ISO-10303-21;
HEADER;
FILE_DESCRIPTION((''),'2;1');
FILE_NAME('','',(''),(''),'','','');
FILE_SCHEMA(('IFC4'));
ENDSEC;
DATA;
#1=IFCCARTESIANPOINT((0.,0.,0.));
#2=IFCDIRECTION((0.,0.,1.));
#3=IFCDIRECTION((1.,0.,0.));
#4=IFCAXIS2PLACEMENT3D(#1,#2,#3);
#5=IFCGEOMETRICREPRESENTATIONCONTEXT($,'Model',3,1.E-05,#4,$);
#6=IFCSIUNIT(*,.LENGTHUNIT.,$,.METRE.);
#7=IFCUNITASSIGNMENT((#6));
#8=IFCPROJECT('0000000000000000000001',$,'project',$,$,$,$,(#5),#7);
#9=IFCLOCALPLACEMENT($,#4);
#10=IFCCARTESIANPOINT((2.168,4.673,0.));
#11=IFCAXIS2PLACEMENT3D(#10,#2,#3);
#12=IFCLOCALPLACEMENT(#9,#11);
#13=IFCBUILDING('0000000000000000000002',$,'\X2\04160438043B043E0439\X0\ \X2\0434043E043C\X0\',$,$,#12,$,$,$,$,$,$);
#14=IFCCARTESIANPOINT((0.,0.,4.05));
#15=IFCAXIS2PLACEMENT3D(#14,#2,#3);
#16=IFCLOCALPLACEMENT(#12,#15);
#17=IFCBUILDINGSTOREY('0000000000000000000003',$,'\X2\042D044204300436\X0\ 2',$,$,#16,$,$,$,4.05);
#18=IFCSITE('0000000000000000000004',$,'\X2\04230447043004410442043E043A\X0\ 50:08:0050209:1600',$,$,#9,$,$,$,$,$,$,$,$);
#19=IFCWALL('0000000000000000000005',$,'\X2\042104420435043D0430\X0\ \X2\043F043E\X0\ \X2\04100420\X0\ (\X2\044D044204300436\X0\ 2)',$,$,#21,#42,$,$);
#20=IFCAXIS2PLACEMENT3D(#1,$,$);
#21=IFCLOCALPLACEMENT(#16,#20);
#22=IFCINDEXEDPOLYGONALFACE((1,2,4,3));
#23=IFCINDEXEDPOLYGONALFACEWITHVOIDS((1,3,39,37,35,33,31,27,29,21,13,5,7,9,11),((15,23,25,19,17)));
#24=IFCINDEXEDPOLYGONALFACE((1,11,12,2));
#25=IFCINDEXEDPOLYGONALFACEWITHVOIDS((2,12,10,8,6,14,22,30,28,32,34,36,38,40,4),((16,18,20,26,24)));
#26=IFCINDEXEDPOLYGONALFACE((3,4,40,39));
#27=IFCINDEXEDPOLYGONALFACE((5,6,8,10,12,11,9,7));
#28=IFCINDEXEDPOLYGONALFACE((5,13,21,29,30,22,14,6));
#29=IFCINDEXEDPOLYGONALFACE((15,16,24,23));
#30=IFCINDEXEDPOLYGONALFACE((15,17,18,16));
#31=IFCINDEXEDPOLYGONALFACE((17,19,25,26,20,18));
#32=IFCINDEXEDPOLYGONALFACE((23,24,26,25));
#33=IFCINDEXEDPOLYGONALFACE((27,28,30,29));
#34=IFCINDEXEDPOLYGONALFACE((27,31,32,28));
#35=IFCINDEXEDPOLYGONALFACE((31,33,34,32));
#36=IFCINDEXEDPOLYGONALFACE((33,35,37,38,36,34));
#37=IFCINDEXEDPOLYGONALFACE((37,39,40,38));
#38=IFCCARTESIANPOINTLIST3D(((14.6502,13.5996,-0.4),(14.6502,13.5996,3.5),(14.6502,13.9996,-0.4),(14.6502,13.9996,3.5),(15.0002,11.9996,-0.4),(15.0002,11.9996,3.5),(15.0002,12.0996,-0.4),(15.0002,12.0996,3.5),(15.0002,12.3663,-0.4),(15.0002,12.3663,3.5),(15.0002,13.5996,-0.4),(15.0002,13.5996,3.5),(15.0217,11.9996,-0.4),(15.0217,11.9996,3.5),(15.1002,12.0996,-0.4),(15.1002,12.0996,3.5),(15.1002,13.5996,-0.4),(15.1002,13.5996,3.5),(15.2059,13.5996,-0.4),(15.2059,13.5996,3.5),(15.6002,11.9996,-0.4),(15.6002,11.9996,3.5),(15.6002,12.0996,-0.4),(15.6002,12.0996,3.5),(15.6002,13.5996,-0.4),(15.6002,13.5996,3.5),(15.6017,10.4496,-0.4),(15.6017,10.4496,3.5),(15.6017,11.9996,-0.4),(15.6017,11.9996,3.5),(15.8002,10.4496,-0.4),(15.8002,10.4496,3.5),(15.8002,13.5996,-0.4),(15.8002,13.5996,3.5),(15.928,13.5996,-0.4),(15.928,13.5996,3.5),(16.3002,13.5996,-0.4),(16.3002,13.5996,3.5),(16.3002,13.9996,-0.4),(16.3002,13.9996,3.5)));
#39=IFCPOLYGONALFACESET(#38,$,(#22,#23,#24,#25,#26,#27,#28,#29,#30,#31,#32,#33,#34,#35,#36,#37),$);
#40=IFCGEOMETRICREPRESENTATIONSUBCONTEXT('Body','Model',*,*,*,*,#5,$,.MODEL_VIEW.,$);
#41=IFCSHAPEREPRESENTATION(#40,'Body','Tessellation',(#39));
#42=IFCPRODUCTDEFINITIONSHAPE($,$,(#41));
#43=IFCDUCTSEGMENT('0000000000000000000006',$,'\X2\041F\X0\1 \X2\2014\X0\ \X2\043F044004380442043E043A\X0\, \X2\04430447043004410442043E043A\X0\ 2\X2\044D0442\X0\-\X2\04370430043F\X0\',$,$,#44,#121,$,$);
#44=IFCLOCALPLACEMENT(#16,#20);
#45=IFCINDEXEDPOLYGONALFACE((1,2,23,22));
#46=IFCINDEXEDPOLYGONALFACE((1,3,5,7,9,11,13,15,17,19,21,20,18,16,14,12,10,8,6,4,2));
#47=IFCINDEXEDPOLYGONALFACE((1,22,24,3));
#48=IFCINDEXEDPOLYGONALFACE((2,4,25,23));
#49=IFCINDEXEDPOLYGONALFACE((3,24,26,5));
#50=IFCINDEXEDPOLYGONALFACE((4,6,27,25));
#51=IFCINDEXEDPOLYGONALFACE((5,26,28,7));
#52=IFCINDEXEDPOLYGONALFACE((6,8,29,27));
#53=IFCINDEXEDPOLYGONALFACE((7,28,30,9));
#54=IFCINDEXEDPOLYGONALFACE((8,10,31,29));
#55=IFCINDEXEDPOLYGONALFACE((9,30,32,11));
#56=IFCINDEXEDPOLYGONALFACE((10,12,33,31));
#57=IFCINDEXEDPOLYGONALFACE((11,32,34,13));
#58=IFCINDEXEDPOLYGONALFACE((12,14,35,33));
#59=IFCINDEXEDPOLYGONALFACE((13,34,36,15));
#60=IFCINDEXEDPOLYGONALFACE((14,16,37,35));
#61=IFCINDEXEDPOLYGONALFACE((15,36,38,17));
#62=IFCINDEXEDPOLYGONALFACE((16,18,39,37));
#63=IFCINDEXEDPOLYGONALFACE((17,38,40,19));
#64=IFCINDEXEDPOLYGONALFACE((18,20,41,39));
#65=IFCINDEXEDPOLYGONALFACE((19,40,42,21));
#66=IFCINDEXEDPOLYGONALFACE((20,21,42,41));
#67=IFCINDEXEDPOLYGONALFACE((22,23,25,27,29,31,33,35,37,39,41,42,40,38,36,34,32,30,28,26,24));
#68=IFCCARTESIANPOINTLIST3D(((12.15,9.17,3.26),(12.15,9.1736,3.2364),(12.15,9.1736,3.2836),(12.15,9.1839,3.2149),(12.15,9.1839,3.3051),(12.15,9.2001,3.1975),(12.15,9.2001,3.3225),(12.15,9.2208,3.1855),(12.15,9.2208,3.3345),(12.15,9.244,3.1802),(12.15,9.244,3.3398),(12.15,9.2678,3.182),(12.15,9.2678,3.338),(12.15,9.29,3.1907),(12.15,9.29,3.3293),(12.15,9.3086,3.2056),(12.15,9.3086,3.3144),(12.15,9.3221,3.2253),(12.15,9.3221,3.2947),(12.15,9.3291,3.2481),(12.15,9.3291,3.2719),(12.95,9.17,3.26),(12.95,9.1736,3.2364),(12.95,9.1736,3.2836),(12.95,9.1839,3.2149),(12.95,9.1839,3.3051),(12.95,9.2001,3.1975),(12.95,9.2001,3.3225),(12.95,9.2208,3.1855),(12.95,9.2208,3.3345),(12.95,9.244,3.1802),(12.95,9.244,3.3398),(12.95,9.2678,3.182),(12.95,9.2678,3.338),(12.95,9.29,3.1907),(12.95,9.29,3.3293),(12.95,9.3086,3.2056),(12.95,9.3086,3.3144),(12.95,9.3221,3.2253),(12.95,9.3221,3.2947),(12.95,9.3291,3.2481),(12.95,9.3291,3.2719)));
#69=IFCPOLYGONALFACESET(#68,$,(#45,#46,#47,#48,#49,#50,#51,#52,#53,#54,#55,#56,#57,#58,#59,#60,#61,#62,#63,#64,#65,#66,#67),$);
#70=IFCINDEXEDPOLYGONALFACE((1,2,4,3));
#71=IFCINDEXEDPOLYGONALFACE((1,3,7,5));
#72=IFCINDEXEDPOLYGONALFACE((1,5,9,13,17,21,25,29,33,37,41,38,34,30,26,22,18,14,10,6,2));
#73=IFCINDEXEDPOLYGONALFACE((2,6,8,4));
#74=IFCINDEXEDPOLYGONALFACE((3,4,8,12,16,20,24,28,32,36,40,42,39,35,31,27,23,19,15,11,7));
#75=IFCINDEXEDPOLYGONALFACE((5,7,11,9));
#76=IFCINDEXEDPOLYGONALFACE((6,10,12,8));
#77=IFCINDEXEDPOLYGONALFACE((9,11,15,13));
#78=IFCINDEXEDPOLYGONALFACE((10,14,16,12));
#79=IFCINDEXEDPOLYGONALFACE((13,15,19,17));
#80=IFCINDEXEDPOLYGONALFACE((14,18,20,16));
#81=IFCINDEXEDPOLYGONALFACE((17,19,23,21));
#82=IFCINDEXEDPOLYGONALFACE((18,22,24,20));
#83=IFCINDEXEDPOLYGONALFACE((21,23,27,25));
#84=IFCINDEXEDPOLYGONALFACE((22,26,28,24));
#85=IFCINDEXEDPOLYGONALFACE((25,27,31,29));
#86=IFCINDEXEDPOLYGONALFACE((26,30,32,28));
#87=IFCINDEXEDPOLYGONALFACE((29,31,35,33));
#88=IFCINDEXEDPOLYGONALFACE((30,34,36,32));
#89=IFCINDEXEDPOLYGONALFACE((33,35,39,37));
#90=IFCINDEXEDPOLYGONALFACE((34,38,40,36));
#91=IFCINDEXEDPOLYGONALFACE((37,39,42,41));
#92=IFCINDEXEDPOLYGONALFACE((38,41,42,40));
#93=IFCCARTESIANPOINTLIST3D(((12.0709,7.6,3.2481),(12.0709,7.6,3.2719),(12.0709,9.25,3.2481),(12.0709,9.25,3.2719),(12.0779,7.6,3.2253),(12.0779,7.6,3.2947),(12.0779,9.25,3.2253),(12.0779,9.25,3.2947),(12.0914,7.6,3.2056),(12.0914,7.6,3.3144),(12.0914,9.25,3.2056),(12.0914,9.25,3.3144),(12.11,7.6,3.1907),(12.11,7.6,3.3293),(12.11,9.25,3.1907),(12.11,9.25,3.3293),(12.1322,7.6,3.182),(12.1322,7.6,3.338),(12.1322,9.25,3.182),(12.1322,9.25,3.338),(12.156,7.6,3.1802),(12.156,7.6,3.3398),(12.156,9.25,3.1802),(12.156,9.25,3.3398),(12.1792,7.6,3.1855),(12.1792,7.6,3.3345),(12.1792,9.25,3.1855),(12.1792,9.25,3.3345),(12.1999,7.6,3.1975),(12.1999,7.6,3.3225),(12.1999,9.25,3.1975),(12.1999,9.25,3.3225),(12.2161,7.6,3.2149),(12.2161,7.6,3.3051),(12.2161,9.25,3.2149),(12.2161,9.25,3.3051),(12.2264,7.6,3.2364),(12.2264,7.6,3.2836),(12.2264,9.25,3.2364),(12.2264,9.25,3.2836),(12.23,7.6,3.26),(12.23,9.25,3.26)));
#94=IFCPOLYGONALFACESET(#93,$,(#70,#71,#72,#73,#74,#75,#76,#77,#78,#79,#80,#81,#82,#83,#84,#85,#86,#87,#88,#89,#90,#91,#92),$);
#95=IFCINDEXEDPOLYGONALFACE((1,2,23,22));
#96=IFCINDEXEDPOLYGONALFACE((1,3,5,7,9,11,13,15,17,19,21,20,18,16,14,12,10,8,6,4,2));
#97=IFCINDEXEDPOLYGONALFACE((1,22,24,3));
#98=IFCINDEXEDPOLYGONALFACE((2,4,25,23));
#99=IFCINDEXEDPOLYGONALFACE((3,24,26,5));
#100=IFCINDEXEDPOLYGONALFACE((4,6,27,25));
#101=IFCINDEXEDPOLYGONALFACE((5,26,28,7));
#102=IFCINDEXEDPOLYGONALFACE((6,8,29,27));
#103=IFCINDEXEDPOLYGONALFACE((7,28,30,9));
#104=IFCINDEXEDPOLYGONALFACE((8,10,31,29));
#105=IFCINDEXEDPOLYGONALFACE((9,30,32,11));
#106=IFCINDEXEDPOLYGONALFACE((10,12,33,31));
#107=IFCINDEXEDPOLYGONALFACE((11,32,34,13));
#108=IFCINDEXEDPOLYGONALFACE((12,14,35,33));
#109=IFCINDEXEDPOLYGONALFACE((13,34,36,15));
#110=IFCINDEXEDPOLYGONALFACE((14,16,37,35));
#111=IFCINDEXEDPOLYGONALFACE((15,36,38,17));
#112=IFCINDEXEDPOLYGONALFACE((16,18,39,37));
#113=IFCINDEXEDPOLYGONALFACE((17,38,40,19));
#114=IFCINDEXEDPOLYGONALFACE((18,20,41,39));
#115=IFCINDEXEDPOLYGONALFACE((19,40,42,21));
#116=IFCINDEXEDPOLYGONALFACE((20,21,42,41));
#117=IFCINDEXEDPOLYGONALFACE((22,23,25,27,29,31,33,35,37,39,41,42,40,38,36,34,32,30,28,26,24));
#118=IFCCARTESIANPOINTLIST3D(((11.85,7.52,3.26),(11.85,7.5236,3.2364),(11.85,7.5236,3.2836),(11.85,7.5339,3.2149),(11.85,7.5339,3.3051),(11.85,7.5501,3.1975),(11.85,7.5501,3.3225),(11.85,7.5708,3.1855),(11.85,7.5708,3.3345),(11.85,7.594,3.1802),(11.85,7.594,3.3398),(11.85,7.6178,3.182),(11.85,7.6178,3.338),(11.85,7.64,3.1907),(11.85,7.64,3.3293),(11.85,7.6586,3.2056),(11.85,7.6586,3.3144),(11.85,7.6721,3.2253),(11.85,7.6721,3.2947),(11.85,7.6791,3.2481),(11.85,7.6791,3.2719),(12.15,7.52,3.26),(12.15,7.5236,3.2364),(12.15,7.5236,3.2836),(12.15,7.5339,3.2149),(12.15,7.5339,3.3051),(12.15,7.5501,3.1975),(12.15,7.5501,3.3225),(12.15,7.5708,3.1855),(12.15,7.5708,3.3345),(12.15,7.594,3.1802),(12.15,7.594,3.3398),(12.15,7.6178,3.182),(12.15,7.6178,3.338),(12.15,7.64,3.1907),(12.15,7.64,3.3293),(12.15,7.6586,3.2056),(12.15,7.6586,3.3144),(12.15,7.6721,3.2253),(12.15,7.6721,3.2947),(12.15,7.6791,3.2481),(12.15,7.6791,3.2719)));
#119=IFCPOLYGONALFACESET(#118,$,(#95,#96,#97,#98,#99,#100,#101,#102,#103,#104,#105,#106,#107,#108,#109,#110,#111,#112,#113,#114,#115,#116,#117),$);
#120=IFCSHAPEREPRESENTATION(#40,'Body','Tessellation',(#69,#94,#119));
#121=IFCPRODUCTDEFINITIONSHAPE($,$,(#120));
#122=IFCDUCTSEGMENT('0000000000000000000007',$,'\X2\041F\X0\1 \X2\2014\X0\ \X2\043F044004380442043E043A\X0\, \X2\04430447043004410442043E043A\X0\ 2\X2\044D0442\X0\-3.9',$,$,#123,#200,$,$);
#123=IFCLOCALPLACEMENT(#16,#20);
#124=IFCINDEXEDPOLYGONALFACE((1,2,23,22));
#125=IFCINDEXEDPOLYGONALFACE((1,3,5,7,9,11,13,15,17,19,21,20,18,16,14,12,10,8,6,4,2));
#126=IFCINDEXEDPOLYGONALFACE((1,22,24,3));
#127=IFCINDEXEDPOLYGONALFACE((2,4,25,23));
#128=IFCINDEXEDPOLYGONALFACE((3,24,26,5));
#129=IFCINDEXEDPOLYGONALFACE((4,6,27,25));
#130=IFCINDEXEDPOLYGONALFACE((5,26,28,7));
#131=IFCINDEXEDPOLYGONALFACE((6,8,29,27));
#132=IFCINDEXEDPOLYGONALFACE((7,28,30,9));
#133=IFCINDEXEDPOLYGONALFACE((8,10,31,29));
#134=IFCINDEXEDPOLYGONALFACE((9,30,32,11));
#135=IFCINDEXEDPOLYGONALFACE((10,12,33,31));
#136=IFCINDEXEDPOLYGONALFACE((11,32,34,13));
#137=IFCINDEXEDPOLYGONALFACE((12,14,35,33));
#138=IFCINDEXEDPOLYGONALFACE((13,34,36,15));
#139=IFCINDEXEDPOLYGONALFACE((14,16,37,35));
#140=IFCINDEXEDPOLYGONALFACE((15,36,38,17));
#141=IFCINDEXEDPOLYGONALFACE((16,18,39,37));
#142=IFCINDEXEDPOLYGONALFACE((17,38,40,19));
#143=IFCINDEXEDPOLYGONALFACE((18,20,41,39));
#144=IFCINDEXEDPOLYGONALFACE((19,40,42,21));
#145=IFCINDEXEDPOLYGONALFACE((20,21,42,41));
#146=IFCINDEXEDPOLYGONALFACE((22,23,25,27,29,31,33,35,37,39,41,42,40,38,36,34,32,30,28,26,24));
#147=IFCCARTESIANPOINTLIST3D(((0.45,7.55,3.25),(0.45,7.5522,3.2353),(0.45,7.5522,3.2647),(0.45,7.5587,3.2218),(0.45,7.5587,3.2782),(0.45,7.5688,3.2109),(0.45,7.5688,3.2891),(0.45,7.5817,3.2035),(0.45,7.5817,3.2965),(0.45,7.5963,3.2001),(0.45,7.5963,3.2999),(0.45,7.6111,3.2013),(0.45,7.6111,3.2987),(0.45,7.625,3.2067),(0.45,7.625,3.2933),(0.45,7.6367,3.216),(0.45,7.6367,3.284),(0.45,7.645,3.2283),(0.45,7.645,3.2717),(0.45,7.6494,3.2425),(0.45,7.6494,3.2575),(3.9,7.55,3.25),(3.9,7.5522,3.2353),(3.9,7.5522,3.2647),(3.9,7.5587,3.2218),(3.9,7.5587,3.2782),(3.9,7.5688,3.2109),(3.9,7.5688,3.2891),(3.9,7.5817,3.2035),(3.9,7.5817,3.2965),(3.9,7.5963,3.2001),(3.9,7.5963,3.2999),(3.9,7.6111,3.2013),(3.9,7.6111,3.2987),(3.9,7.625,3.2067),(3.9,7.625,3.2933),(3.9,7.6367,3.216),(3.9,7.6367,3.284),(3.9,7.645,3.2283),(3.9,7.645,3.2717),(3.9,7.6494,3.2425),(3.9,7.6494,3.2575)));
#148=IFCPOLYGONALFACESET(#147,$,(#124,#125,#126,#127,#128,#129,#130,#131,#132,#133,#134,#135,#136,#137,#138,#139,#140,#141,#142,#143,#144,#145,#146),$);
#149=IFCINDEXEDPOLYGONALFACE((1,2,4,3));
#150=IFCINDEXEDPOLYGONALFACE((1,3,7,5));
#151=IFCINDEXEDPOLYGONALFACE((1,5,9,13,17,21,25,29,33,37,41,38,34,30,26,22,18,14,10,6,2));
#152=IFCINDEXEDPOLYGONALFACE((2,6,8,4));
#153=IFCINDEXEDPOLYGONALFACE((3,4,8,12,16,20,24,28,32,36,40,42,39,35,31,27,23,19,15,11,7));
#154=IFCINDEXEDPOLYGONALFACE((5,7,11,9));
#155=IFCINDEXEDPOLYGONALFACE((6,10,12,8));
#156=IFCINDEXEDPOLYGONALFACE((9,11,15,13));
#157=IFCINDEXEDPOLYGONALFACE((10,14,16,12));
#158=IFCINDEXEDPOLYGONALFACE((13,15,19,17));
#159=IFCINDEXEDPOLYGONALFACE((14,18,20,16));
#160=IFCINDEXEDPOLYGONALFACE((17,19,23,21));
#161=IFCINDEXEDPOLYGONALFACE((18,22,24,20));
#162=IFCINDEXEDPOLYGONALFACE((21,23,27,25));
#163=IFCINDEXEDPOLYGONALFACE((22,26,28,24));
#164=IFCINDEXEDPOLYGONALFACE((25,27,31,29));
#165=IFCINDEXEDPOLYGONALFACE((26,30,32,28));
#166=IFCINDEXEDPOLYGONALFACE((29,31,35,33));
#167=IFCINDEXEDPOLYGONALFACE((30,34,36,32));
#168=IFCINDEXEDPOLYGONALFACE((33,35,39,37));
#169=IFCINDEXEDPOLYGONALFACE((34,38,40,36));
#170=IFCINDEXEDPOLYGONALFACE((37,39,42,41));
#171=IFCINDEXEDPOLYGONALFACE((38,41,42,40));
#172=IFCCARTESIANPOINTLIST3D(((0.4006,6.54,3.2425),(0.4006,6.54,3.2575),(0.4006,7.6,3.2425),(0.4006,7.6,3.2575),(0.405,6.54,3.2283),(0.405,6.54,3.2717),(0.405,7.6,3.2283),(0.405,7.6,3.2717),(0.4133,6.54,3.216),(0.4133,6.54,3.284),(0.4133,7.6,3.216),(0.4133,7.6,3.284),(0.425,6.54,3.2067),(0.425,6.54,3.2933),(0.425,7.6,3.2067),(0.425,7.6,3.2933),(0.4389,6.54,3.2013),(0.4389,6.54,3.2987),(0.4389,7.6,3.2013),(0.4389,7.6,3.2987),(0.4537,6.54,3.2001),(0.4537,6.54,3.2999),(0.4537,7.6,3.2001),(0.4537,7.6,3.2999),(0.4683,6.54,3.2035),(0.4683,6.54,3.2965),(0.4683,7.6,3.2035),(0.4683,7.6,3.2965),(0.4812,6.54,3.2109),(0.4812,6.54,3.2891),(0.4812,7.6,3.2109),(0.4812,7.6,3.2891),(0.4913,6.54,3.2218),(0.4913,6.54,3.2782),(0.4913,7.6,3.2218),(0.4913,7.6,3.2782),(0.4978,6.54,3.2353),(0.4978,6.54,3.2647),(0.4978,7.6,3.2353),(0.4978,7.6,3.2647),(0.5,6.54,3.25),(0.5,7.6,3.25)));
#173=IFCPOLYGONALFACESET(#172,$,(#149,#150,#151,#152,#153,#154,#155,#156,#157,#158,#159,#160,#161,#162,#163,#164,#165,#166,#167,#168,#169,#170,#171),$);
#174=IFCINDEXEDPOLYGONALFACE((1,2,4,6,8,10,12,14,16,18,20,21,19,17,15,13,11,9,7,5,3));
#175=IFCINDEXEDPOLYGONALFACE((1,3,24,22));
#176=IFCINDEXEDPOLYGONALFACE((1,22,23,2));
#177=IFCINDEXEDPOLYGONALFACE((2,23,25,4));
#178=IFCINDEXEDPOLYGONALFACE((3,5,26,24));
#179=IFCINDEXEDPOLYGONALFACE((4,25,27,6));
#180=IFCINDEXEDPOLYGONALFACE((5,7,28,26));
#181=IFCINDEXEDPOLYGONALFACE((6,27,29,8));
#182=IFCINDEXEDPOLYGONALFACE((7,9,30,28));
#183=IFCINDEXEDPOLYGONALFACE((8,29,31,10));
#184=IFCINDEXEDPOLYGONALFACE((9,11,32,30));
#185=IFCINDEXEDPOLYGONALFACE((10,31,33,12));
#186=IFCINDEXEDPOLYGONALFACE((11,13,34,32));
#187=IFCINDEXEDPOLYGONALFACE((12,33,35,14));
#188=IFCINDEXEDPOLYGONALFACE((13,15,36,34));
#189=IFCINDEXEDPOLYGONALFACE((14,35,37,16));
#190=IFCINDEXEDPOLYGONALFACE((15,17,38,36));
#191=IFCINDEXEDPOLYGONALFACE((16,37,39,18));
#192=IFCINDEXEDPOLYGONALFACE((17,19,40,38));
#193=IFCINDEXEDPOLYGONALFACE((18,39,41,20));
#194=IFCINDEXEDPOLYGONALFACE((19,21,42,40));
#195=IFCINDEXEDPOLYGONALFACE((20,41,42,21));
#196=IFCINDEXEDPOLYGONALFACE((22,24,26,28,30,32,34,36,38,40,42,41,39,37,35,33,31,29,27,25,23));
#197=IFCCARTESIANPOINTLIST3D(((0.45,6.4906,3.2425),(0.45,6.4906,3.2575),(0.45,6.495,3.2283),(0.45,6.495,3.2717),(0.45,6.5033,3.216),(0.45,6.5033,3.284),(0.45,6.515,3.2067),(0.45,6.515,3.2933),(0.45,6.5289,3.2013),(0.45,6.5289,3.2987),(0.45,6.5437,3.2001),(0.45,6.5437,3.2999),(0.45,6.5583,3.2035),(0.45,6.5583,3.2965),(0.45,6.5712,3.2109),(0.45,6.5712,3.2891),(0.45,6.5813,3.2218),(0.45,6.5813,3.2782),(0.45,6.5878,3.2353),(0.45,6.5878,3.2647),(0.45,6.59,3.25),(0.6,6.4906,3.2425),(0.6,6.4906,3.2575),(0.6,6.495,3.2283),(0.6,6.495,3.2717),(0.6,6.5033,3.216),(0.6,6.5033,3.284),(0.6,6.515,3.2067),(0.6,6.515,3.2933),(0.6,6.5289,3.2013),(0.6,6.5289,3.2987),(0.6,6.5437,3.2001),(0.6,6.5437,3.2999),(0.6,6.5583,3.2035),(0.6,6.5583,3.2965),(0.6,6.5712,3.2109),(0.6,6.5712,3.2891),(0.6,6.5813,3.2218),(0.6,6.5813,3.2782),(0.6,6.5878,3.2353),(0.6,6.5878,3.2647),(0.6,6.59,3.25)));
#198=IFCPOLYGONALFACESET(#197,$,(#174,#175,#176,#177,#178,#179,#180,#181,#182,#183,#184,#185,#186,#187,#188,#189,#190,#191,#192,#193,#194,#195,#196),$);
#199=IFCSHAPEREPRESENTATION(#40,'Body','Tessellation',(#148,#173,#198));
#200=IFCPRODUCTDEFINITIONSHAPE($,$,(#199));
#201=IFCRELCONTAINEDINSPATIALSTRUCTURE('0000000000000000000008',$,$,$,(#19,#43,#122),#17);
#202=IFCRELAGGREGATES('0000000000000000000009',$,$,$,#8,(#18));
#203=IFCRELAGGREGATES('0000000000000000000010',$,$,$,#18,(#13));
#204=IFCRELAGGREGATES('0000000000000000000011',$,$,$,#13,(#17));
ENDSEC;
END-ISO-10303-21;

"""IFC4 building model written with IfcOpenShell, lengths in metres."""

from ifc_helpers import new_model, si_unit, frame, origin_with_axes, origin_2d, place, context, subcontext, project, spatial, polyline, circle, outline, extrude, element, save


model = new_model("IFC4")

# Units and contexts
model_context = context("Model", 3, precision=1e-05, world=origin_with_axes())
body_context = subcontext(model_context, "Body", "Model", "MODEL_VIEW")
ifc_project = project(units=[si_unit("LENGTHUNIT", "METRE")], contexts=[model_context])

# Site, building, storey
site_placement = place(None, origin_with_axes())
site = spatial("IfcSite", under=ifc_project, at=site_placement, Name="Участок 50:08:0050209:1600")
building_placement = place(site_placement, frame((2.168, 4.673, 0.0), z_axis=(0.0, 0.0, 1.0), x_axis=(1.0, 0.0, 0.0)))
building = spatial("IfcBuilding", under=site, at=building_placement, Name="Жилой дом")
storey_placement = place(building_placement, frame((0.0, 0.0, 4.05), z_axis=(0.0, 0.0, 1.0), x_axis=(1.0, 0.0, 0.0)))
storey = spatial("IfcBuildingStorey", under=building, at=storey_placement, Name="Этаж 2", Elevation=4.05)

# Wall
wall_1_placement = place(storey_placement, frame((0.0, 0.0, -4.05), z_axis=(0.0, 0.0, 1.0), x_axis=(1.0, 0.0, 0.0)))
element("IfcWall", 1, at=wall_1_placement, inside=storey, Name="Стена по АР (этаж 2)", context=body_context, shape_type="SweptSolid", body=[
    extrude(outline(polyline([(15.6017, 11.9996), (15.6002, 11.9996), (15.0217, 11.9996), (15.0002, 11.9996), (15.0002, 12.0996), (15.0002, 12.3663), (15.0002, 13.5996), (14.6502, 13.5996), (14.6502, 13.9996), (16.3002, 13.9996), (16.3002, 13.5996), (15.928, 13.5996), (15.8002, 13.5996), (15.8002, 10.4496), (15.6017, 10.4496), (15.6017, 11.9996)]), holes=[polyline([(15.1002, 13.5996), (15.1002, 12.0996), (15.6002, 12.0996), (15.6002, 13.5996), (15.2059, 13.5996), (15.1002, 13.5996)])]), frame((0.0, 0.0, 3.65), z_axis=(0.0, 0.0, 1.0), x_axis=(1.0, 0.0, 0.0)), (0.0, 0.0, 1.0), 3.9),
])

# Duct segments
duct_segment_1_placement = place(storey_placement, frame((0.0, 0.0, -4.05), z_axis=(0.0, 0.0, 1.0), x_axis=(1.0, 0.0, 0.0)))
element("IfcDuctSegment", 2, at=duct_segment_1_placement, inside=storey, Name="П1 — приток, участок 2эт-зап", context=body_context, shape_type="SweptSolid", body=[
    extrude(circle(Radius=0.08, at=origin_2d()), frame((12.95, 9.25, 7.31), z_axis=(-1.0, 0.0, 0.0), x_axis=(0.0, -1.0, 0.0)), (0.0, 0.0, 1.0), 0.8),
    extrude(circle(Radius=0.08, at=origin_2d()), frame((12.15, 9.25, 7.31), z_axis=(0.0, -1.0, 0.0), x_axis=(1.0, 0.0, 0.0)), (0.0, 0.0, 1.0), 1.65),
    extrude(circle(Radius=0.08, at=origin_2d()), frame((12.15, 7.6, 7.31), z_axis=(-1.0, 0.0, 0.0), x_axis=(0.0, -1.0, 0.0)), (0.0, 0.0, 1.0), 0.3),
])
duct_segment_2_placement = place(storey_placement, frame((0.0, 0.0, -4.05), z_axis=(0.0, 0.0, 1.0), x_axis=(1.0, 0.0, 0.0)))
element("IfcDuctSegment", 3, at=duct_segment_2_placement, inside=storey, Name="П1 — приток, участок 2эт-3.9", context=body_context, shape_type="SweptSolid", body=[
    extrude(circle(Radius=0.05, at=origin_2d()), frame((3.9, 7.6, 7.3), z_axis=(-1.0, 0.0, 0.0), x_axis=(0.0, -1.0, 0.0)), (0.0, 0.0, 1.0), 3.45),
    extrude(circle(Radius=0.05, at=origin_2d()), frame((0.45, 7.6, 7.3), z_axis=(0.0, -1.0, 0.0), x_axis=(1.0, 0.0, 0.0)), (0.0, 0.0, 1.0), 1.06),
    extrude(circle(Radius=0.05, at=origin_2d()), frame((0.45, 6.54, 7.3), z_axis=(1.0, 0.0, 0.0), x_axis=(0.0, 1.0, 0.0)), (0.0, 0.0, 1.0), 0.15),
])

save(model, "model.ifc")
